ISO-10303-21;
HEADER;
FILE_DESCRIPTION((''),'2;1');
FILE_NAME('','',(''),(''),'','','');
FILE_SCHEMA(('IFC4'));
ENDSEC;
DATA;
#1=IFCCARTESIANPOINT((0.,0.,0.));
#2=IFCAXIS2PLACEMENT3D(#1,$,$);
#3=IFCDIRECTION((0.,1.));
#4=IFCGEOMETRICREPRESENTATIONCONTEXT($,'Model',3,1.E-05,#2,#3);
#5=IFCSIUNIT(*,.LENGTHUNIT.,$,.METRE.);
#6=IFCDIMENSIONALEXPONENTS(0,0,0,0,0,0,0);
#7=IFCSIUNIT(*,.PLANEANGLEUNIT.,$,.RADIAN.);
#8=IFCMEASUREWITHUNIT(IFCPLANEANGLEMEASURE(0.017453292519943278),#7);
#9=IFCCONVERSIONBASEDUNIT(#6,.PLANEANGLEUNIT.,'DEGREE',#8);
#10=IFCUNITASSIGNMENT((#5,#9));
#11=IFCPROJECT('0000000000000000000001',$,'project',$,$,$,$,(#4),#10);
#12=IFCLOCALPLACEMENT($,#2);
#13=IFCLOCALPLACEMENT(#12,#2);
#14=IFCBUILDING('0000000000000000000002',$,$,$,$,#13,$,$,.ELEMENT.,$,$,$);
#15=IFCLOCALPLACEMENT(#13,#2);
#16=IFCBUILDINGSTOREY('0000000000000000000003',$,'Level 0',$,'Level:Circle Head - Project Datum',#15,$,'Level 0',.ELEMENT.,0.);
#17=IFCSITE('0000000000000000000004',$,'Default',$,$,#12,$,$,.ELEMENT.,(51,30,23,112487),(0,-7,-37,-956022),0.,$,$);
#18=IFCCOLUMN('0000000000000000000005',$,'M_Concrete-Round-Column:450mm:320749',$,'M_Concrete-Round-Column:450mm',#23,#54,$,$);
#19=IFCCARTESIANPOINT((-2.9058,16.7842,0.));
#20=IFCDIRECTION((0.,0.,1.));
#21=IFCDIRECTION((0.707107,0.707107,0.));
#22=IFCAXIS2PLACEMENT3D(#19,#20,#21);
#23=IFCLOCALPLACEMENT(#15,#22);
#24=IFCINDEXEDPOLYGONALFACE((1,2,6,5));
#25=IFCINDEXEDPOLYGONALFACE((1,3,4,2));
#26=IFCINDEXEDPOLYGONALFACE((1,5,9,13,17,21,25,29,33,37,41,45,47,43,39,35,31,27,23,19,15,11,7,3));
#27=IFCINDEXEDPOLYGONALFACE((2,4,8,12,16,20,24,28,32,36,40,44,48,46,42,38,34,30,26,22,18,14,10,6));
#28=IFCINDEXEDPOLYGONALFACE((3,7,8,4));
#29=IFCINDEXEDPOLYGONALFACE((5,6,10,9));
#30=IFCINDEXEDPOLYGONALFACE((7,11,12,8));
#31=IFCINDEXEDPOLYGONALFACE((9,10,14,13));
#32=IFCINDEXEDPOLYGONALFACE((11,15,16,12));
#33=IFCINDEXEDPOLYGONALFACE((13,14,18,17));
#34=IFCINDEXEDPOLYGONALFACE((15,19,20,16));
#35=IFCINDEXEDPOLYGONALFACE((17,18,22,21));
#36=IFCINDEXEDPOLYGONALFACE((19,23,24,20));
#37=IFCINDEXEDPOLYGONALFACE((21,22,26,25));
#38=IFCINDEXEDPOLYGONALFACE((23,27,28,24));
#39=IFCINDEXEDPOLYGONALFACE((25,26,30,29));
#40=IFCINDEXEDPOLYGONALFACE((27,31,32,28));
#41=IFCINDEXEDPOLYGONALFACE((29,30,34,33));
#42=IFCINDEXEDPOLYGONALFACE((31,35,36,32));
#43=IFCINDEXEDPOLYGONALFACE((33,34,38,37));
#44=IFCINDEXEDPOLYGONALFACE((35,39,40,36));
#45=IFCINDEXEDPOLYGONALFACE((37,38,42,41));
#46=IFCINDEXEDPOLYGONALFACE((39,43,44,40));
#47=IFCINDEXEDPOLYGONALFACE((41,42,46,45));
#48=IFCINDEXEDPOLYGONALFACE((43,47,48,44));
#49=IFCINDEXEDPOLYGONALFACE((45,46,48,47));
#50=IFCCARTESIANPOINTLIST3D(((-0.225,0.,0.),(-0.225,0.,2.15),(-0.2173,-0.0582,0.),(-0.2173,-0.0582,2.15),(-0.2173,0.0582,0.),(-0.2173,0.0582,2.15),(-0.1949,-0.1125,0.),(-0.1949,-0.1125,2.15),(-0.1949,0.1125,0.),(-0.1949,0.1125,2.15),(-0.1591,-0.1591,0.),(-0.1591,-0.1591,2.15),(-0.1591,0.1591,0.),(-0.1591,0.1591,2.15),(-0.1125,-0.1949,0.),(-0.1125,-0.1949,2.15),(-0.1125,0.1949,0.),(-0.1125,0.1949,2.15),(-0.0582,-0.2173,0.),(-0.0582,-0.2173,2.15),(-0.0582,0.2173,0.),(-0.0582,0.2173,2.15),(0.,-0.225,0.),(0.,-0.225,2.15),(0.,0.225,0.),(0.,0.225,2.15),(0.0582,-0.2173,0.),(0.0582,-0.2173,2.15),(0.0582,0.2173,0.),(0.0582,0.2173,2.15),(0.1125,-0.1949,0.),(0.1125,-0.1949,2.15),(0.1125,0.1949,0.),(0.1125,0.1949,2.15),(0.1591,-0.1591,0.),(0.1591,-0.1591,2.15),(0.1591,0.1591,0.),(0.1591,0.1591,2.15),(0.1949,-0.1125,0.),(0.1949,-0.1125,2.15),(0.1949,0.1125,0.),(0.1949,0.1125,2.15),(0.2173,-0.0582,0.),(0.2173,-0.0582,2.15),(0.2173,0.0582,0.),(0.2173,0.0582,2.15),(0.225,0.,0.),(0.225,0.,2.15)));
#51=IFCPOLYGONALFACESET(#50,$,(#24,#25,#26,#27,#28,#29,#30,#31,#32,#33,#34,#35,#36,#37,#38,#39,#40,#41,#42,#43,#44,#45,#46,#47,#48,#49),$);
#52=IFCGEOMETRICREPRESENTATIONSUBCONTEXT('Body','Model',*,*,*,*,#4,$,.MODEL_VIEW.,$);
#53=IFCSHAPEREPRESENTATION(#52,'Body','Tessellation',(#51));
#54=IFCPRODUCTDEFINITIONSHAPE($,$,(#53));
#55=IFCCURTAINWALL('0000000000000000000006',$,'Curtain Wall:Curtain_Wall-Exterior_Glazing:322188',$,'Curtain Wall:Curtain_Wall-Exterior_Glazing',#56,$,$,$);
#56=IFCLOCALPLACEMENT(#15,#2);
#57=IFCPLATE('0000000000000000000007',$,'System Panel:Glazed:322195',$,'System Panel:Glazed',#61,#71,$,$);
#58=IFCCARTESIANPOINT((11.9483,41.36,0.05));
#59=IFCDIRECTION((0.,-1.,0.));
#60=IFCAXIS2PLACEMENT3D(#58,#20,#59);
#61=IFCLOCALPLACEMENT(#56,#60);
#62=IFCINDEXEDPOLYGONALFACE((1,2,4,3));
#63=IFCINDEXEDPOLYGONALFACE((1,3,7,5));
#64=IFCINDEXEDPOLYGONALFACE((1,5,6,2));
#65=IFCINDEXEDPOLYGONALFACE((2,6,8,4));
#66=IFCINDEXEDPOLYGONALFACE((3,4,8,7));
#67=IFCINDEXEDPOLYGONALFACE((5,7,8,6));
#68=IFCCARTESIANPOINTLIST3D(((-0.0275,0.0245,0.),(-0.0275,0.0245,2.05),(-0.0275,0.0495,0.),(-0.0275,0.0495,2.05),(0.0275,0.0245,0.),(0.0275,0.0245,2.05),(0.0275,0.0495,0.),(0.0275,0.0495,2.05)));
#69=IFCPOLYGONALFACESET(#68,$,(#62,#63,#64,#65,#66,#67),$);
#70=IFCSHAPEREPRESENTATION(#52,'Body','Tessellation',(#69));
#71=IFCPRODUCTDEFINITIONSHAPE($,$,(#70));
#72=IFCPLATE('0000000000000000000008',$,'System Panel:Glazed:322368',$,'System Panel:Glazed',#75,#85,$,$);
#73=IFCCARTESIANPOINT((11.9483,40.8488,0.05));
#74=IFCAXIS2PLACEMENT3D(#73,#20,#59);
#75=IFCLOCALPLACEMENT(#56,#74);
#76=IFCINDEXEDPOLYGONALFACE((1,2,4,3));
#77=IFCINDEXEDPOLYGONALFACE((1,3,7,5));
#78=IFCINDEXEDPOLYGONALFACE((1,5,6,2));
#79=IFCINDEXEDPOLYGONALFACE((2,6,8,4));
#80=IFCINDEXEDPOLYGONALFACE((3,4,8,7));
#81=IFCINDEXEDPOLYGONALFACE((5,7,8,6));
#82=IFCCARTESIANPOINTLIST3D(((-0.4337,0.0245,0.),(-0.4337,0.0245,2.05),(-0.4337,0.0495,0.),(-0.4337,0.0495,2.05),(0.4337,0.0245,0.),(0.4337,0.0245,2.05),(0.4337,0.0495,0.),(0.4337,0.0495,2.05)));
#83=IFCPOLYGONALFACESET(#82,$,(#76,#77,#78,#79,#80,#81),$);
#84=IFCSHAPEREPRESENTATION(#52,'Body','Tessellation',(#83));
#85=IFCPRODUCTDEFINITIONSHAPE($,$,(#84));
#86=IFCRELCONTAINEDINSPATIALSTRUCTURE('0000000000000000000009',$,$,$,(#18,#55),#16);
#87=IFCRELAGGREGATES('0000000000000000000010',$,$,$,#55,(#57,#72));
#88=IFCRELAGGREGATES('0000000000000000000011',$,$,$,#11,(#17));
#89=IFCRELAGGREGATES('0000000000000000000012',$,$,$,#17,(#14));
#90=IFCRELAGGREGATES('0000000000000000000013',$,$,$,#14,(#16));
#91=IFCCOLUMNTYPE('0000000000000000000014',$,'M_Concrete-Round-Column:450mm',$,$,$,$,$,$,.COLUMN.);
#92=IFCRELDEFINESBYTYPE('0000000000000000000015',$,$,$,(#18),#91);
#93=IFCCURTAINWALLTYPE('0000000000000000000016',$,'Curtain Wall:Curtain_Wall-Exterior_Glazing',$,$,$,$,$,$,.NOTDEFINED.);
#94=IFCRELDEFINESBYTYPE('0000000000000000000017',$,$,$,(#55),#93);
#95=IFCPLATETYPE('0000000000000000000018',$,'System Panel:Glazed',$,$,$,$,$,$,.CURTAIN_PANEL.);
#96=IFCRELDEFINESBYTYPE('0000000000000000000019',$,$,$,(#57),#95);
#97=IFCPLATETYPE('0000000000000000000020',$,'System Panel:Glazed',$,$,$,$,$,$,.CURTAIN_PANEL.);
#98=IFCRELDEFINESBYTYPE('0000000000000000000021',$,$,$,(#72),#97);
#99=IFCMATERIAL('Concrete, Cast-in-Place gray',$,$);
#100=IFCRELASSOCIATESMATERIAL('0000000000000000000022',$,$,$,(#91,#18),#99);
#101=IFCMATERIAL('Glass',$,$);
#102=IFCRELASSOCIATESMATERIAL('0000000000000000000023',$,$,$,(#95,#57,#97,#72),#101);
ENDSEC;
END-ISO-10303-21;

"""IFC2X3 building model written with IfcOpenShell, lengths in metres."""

from ifc_helpers import new_model, entity, si_unit, converted_unit, direction, frame, frame_2d, origin, origin_2d_with_axis, place, context, subcontext, project, spatial, rectangle, circle, extrude, source, transform, mapped, material, type_object, type_shapes, element, aggregate, save


model = new_model("IFC2X3")

# Units and contexts
model_context = context("Model", 3, precision=1e-05, world=origin(), true_north=direction((0.0, 1.0)))
body_context = subcontext(model_context, "Body", "Model", "MODEL_VIEW")
ifc_project = project(units=[si_unit("LENGTHUNIT", "METRE"), converted_unit("PLANEANGLEUNIT", "DEGREE", entity("IfcPlaneAngleMeasure", 0.017453292519943278), si_unit("PLANEANGLEUNIT", "RADIAN"), dimensions=[0, 0, 0, 0, 0, 0, 0])], contexts=[model_context])

# Site, building, storey
site_placement = place(None, origin())
site = spatial("IfcSite", under=ifc_project, at=site_placement, Name="Default", CompositionType="ELEMENT", RefLatitude=(51, 30, 23, 112487), RefLongitude=(0, -7, -37, -956022), RefElevation=0.0)
building_placement = place(site_placement, origin())
building = spatial("IfcBuilding", under=site, at=building_placement, CompositionType="ELEMENT")
storey_placement = place(building_placement, origin())
storey = spatial("IfcBuildingStorey", under=building, at=storey_placement, Name="Level 0", ObjectType="Level:Circle Head - Project Datum", LongName="Level 0", CompositionType="ELEMENT", Elevation=0.0)

# Column
ifc_material_1 = material(Name="Concrete, Cast-in-Place gray")
column_type_1 = type_object("IfcColumnType", Name="M_Concrete-Round-Column:450mm", PredefinedType="COLUMN", material=ifc_material_1)
shared_shape_1 = source(origin(), body_context, "Body", "SweptSolid", [
    extrude(circle(Radius=0.225, at=frame_2d((0.0, 0.0), x_axis=(1.0, 0.0))), origin(), (0.0, 0.0, 1.0), 2.15),
])
type_shapes(column_type_1, [shared_shape_1])
column_1_placement = place(storey_placement, frame((-2.9058, 16.7842, 0.0), z_axis=(0.0, 0.0, 1.0), x_axis=(0.707107, 0.707107, 0.0)))
element("IfcColumn", 1, at=column_1_placement, inside=storey, type_object=column_type_1, material=ifc_material_1, Name="M_Concrete-Round-Column:450mm:320749", ObjectType="M_Concrete-Round-Column:450mm", context=body_context, shape_type="MappedRepresentation", body=[
    mapped(shared_shape_1, transform((0.0, 0.0, 0.0), scale=1.0)),
])

# Curtain wall, plates
curtain_wall_type = type_object("IfcCurtainWallType", Name="Curtain Wall:Curtain_Wall-Exterior_Glazing", PredefinedType="NOTDEFINED")
curtain_wall_placement = place(storey_placement, origin())
curtain_wall = element("IfcCurtainWall", 2, at=curtain_wall_placement, inside=storey, type_object=curtain_wall_type, Name="Curtain Wall:Curtain_Wall-Exterior_Glazing:322188", ObjectType="Curtain Wall:Curtain_Wall-Exterior_Glazing")
ifc_material_2 = material(Name="Glass")
plate_type_1 = type_object("IfcPlateType", Name="System Panel:Glazed", PredefinedType="CURTAIN_PANEL", material=ifc_material_2)
shared_shape_2 = source(origin(), body_context, "Body", "SweptSolid", [
    extrude(rectangle(XDim=0.025, YDim=0.055, at=origin_2d_with_axis()), frame((0.0, 0.037, 0.0), z_axis=(0.0, 0.0, 1.0), x_axis=(0.0, 1.0, 0.0)), (0.0, 0.0, 1.0), 2.05),
])
type_shapes(plate_type_1, [shared_shape_2])
plate_1_placement = place(curtain_wall_placement, frame((11.9483, 41.36, 0.05), z_axis=(0.0, 0.0, 1.0), x_axis=(0.0, -1.0, 0.0)))
plate_1 = element("IfcPlate", 3, at=plate_1_placement, type_object=plate_type_1, material=ifc_material_2, Name="System Panel:Glazed:322195", ObjectType="System Panel:Glazed", context=body_context, shape_type="MappedRepresentation", body=[
    mapped(shared_shape_2, transform((0.0, 0.0, 0.0), scale=1.0)),
])
plate_type_2 = type_object("IfcPlateType", Name="System Panel:Glazed", PredefinedType="CURTAIN_PANEL", material=ifc_material_2)
shared_shape_3 = source(origin(), body_context, "Body", "SweptSolid", [
    extrude(rectangle(XDim=0.025, YDim=0.8675, at=origin_2d_with_axis()), frame((0.0, 0.037, 0.0), z_axis=(0.0, 0.0, 1.0), x_axis=(0.0, 1.0, 0.0)), (0.0, 0.0, 1.0), 2.05),
])
type_shapes(plate_type_2, [shared_shape_3])
plate_2_placement = place(curtain_wall_placement, frame((11.9483, 40.8488, 0.05), z_axis=(0.0, 0.0, 1.0), x_axis=(0.0, -1.0, 0.0)))
plate_2 = element("IfcPlate", 4, at=plate_2_placement, type_object=plate_type_2, material=ifc_material_2, Name="System Panel:Glazed:322368", ObjectType="System Panel:Glazed", context=body_context, shape_type="MappedRepresentation", body=[
    mapped(shared_shape_3, transform((0.0, 0.0, 0.0), scale=1.0)),
])
aggregate(curtain_wall, [plate_1, plate_2])

save(model, "model.ifc")
